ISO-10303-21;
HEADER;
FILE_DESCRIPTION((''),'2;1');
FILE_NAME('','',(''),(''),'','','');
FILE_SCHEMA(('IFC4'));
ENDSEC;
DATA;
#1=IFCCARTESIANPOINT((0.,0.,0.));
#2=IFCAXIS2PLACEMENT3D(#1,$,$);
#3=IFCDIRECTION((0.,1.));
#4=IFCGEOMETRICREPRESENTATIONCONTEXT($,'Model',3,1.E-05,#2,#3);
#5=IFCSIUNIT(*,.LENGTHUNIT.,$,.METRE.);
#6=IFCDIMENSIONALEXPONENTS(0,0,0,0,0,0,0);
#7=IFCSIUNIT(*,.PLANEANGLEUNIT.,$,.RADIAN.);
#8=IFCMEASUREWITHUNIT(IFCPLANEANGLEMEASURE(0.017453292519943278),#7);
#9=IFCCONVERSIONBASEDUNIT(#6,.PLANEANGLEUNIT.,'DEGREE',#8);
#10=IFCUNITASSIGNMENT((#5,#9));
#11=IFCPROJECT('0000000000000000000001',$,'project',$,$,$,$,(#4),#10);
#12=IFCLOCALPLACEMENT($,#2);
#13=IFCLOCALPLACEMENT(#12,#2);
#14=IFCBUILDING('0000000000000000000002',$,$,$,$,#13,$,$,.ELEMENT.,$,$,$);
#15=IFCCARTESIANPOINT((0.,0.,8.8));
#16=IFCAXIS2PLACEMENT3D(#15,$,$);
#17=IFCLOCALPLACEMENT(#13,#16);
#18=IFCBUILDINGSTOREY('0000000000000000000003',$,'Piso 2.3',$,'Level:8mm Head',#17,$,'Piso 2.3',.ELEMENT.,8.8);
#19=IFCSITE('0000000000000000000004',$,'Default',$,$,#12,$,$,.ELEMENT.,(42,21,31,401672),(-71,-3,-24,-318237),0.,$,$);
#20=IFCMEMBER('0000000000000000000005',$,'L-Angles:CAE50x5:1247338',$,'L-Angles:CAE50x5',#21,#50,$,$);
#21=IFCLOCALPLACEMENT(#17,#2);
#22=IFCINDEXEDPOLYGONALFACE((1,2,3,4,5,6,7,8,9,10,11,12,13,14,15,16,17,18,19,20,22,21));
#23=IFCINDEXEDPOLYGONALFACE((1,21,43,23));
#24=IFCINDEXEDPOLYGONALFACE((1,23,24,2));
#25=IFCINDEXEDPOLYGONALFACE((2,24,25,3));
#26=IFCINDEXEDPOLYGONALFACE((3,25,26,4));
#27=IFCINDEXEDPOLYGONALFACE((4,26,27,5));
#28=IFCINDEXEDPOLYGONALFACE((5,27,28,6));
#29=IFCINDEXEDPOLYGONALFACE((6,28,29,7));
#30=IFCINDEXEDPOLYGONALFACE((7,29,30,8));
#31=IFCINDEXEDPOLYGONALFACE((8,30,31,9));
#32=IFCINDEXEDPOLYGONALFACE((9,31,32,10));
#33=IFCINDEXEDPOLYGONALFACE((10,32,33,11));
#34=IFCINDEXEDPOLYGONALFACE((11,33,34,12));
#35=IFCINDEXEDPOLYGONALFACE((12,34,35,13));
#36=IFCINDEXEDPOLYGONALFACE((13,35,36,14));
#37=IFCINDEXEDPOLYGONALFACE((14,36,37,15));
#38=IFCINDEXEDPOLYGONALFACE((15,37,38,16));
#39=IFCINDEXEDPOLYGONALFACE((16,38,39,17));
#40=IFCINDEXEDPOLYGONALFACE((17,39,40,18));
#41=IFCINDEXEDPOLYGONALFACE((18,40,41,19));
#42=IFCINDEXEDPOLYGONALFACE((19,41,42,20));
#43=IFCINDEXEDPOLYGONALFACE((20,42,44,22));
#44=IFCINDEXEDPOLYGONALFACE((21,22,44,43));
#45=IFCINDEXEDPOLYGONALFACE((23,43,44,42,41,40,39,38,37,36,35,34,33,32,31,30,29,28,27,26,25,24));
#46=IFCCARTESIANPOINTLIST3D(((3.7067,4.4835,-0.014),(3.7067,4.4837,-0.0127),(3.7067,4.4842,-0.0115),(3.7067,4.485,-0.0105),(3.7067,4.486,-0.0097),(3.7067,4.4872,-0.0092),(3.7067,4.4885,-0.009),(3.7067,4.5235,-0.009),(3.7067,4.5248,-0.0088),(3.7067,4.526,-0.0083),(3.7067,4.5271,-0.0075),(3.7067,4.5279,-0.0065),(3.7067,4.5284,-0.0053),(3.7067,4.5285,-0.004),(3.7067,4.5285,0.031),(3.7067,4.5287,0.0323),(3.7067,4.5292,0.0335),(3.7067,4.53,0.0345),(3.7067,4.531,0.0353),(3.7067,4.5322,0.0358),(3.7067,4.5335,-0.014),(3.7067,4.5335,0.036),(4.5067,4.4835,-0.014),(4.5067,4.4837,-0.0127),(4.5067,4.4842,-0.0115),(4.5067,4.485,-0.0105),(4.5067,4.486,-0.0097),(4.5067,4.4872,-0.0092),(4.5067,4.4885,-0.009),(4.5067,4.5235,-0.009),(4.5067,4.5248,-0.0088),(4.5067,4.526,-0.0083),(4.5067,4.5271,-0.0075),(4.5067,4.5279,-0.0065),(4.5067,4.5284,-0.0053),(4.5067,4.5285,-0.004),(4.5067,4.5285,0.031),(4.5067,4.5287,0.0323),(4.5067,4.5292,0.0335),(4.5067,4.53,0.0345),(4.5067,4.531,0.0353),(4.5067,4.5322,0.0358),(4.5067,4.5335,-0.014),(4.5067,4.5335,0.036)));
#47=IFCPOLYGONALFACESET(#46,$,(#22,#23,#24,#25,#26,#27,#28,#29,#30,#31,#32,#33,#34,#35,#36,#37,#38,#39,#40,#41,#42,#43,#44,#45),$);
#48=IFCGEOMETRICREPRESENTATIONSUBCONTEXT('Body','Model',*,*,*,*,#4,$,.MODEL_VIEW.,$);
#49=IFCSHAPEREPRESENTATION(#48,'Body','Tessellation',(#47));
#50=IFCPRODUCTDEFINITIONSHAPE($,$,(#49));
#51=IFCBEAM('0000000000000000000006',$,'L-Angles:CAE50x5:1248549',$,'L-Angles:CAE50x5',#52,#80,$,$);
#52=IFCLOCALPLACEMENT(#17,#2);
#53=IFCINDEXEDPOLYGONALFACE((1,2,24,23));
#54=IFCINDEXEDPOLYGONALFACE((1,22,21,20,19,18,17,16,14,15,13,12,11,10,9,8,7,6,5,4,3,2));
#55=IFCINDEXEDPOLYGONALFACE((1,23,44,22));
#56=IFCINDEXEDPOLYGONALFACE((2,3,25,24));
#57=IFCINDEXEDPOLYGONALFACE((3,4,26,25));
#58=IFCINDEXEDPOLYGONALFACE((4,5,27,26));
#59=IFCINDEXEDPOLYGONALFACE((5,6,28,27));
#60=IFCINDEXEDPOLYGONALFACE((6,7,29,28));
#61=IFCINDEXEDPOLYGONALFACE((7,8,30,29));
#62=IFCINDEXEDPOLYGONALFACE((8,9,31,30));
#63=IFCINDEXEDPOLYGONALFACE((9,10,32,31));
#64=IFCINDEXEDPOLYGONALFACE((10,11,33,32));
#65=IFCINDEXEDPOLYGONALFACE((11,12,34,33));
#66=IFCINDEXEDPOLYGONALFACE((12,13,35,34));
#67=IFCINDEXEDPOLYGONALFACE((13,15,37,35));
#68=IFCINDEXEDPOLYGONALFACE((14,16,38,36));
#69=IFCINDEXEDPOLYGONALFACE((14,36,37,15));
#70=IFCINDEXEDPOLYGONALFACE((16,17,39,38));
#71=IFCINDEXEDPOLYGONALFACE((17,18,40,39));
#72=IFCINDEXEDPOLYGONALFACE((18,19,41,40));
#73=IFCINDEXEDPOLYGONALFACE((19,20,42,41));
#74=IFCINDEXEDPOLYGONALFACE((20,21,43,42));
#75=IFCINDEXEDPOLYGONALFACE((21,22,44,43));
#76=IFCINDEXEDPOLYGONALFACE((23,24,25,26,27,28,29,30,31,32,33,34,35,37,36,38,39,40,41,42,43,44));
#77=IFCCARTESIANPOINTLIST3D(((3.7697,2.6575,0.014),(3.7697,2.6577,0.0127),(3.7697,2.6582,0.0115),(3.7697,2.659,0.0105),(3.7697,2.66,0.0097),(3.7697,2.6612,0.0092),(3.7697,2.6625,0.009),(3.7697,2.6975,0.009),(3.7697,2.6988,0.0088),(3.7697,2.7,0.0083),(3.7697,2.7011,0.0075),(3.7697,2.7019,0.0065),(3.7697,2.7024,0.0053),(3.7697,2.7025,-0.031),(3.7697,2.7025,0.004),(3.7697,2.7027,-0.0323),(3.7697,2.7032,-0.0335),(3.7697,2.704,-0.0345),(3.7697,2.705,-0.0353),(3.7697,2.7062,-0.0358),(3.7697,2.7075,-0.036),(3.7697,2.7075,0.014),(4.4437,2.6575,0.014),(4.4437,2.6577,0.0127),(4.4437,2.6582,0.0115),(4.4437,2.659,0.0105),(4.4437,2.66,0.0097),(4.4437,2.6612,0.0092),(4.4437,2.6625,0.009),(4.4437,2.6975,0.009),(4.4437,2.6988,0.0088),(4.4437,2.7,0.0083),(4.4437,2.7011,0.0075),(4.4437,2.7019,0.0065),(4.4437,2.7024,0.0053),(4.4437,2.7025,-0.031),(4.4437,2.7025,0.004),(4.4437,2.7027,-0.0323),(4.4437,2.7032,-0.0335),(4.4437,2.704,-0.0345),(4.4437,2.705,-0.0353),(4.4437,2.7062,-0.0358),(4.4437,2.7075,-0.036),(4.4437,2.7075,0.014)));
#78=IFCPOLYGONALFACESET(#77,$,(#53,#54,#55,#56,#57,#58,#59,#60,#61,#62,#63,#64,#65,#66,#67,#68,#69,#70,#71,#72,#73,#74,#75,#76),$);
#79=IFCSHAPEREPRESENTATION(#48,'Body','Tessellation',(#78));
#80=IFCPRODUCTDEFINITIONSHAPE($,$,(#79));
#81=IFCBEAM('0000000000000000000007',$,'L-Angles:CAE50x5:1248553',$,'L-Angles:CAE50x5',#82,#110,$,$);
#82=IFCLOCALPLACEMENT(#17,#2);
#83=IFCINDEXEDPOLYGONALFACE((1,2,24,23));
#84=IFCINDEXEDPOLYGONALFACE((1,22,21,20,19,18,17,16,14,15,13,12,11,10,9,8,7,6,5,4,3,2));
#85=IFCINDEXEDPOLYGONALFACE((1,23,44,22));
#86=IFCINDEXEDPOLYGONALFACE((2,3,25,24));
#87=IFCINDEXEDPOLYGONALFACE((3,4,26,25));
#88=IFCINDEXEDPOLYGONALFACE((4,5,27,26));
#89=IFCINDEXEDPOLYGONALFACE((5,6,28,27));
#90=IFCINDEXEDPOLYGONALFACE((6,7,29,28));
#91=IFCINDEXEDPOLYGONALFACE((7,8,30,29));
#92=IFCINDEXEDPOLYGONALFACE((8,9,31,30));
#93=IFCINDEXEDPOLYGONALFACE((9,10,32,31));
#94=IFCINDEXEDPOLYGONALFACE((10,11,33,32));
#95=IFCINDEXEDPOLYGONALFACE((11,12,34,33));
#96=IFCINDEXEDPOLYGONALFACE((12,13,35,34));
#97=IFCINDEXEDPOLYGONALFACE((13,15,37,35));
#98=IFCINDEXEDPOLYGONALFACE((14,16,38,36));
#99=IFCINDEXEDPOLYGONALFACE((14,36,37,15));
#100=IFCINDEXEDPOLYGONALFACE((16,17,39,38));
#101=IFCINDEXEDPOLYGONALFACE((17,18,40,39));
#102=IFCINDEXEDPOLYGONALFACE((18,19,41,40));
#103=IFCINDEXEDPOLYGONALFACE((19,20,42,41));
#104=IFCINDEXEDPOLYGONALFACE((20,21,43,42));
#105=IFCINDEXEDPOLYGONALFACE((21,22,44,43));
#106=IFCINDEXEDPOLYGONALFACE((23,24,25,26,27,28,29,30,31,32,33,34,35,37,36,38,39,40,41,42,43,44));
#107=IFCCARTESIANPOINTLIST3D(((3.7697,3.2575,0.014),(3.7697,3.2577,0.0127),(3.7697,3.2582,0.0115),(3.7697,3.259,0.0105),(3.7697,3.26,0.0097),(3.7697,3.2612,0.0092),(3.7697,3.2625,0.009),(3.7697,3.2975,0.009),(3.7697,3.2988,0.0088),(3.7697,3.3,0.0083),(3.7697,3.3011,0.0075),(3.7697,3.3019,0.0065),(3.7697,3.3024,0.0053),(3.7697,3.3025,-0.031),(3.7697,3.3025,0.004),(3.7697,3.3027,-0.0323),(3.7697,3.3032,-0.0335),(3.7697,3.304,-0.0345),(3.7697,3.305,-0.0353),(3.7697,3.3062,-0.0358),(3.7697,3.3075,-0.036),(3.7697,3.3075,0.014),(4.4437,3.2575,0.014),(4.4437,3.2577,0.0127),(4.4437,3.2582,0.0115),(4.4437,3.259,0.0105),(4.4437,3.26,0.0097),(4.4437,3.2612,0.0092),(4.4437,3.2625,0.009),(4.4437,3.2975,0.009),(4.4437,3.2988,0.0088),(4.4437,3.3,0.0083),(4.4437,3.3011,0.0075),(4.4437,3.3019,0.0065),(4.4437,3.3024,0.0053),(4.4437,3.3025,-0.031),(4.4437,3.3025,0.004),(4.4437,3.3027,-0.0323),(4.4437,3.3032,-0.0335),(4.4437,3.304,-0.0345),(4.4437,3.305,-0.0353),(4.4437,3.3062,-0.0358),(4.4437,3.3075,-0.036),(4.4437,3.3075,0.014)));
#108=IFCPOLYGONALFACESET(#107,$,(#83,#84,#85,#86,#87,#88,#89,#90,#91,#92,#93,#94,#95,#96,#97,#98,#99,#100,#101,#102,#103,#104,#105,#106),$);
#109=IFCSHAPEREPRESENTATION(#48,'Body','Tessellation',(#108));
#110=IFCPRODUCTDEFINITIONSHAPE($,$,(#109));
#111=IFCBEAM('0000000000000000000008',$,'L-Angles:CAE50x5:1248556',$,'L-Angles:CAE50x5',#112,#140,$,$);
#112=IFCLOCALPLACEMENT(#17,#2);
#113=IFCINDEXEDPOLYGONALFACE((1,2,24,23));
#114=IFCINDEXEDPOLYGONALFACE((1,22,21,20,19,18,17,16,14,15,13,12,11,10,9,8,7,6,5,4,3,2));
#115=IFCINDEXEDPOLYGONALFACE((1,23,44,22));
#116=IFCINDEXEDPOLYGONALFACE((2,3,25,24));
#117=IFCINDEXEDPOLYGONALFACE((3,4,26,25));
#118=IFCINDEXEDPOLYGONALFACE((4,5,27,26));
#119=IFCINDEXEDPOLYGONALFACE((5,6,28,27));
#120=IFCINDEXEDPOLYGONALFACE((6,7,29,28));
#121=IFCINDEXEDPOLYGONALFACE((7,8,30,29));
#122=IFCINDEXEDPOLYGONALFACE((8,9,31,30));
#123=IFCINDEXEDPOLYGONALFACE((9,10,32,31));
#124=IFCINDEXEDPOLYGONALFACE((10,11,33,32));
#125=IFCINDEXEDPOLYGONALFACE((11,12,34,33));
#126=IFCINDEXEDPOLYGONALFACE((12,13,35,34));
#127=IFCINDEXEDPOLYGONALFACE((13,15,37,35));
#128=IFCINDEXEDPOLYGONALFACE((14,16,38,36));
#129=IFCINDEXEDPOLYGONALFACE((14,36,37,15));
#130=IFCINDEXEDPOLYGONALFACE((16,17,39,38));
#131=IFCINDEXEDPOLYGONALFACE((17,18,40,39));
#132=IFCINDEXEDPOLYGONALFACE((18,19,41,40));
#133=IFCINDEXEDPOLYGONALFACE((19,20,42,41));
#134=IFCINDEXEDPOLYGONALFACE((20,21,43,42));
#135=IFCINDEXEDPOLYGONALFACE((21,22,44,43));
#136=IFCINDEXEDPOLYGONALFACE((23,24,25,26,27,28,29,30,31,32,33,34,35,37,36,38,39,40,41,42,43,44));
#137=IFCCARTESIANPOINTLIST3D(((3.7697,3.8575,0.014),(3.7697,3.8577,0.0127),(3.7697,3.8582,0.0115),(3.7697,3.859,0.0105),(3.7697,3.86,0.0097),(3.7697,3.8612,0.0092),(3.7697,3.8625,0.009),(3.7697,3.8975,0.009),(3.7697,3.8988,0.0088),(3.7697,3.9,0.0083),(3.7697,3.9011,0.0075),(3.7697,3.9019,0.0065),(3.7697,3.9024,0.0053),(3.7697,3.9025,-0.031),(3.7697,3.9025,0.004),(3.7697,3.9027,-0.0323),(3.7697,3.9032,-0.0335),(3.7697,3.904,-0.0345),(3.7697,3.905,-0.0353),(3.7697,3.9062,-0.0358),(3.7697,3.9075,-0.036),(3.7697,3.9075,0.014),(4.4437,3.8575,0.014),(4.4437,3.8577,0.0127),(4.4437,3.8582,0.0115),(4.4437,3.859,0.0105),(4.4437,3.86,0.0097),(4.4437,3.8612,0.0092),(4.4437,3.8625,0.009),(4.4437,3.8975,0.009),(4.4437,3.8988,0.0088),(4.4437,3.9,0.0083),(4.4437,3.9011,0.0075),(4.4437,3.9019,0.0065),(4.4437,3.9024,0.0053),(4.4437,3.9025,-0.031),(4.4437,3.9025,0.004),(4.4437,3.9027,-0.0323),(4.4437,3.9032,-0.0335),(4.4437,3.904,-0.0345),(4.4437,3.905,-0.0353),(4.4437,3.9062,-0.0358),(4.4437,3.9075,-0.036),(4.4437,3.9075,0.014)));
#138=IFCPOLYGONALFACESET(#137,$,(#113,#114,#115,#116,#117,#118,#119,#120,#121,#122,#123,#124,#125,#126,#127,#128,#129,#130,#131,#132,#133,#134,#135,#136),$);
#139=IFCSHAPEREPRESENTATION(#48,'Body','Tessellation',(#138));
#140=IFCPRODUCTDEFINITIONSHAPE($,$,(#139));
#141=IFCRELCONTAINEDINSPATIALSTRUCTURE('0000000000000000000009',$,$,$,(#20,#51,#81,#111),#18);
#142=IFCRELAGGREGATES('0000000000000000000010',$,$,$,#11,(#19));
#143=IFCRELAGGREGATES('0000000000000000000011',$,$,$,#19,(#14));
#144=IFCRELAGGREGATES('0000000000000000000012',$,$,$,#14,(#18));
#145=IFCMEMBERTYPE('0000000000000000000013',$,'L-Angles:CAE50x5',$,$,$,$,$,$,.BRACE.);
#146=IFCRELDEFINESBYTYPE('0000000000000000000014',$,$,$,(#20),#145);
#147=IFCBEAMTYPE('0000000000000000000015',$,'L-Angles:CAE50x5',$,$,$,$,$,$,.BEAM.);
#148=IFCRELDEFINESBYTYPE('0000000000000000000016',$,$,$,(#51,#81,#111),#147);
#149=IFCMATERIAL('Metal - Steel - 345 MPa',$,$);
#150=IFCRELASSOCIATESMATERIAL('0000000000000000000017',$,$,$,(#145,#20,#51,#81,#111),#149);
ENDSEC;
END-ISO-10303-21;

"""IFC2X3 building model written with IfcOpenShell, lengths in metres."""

from ifc_helpers import new_model, entity, si_unit, converted_unit, direction, frame, frame_2d, origin, place, context, subcontext, project, spatial, polyline, circle_curve, parameter, trimmed, segment, composite_curve, outline, extrude, source, transform, mapped, material, type_object, type_shapes, element, save


model = new_model("IFC2X3")

# Units and contexts
model_context = context("Model", 3, precision=1e-05, world=origin(), true_north=direction((0.0, 1.0)))
body_context = subcontext(model_context, "Body", "Model", "MODEL_VIEW")
ifc_project = project(units=[si_unit("LENGTHUNIT", "METRE"), converted_unit("PLANEANGLEUNIT", "DEGREE", entity("IfcPlaneAngleMeasure", 0.017453292519943278), si_unit("PLANEANGLEUNIT", "RADIAN"), dimensions=[0, 0, 0, 0, 0, 0, 0])], contexts=[model_context])

# Site, building, storey
site_placement = place(None, origin())
site = spatial("IfcSite", under=ifc_project, at=site_placement, Name="Default", CompositionType="ELEMENT", RefLatitude=(42, 21, 31, 401672), RefLongitude=(-71, -3, -24, -318237), RefElevation=0.0)
building_placement = place(site_placement, origin())
building = spatial("IfcBuilding", under=site, at=building_placement, CompositionType="ELEMENT")
storey_placement = place(building_placement, frame((0.0, 0.0, 8.8)))
storey = spatial("IfcBuildingStorey", under=building, at=storey_placement, Name="Piso 2.3", ObjectType="Level:8mm Head", LongName="Piso 2.3", CompositionType="ELEMENT", Elevation=8.8)

# Member
ifc_material = material(Name="Metal - Steel - 345 MPa")
member_type_1 = type_object("IfcMemberType", Name="L-Angles:CAE50x5", PredefinedType="BRACE", material=ifc_material)
shared_shape_1 = source(origin(), body_context, "Body", "SweptSolid", [
    extrude(outline(composite_curve([segment(polyline([(-0.0164, -0.0164), (0.0336, -0.0164)]), True, "CONTINUOUS"), segment(trimmed(circle_curve(frame_2d((0.0286, -0.0164), x_axis=(1.0, 0.0)), 0.005), [parameter(0.0)], [parameter(90.0)], True, "PARAMETER"), True, "CONTINUOUS"), segment(polyline([(0.0286, -0.0114), (-0.0064, -0.0114)]), True, "CONTINUOUS"), segment(trimmed(circle_curve(frame_2d((-0.0064, -0.0064), x_axis=(1.0, 0.0)), 0.005), [parameter(180.0)], [parameter(270.0)], True, "PARAMETER"), False, "CONTINUOUS"), segment(polyline([(-0.0114, -0.0064), (-0.0114, 0.0286)]), True, "CONTINUOUS"), segment(trimmed(circle_curve(frame_2d((-0.0164, 0.0286), x_axis=(1.0, 0.0)), 0.005), [parameter(0.0)], [parameter(90.0)], True, "PARAMETER"), True, "CONTINUOUS"), segment(polyline([(-0.0164, 0.0336), (-0.0164, -0.0164)]), True, "CONTINUOUS")], self_intersect=False)), frame((-0.4, -0.0024, -0.0024), z_axis=(1.0, 0.0, 0.0), x_axis=(0.0, -1.0, 0.0)), (0.0, 0.0, 1.0), 0.8),
])
type_shapes(member_type_1, [shared_shape_1])
member_placement = place(storey_placement, frame((4.1067, 4.5195, 0.0), z_axis=(0.0, 1.0, 0.0), x_axis=(1.0, 0.0, 0.0)))
element("IfcMember", 1, at=member_placement, inside=storey, type_object=member_type_1, material=ifc_material, Name="L-Angles:CAE50x5:1247338", ObjectType="L-Angles:CAE50x5", context=body_context, shape_type="MappedRepresentation", body=[
    mapped(shared_shape_1, transform((0.0, 0.0, 0.0), scale=1.0)),
])

# Beams
beam_type_1 = type_object("IfcBeamType", Name="L-Angles:CAE50x5", PredefinedType="BEAM")
beam_1_placement = place(storey_placement, frame((3.7067, 2.6935, 0.0)))
element("IfcBeam", 2, at=beam_1_placement, inside=storey, type_object=beam_type_1, material=ifc_material, Name="L-Angles:CAE50x5:1248549", ObjectType="L-Angles:CAE50x5", context=body_context, shape_type="SweptSolid", body=[
    extrude(outline(composite_curve([segment(polyline([(-0.0336, -0.0164), (0.0164, -0.0164)]), True, "CONTINUOUS"), segment(polyline([(0.0164, -0.0164), (0.0164, 0.0336)]), True, "CONTINUOUS"), segment(trimmed(circle_curve(frame_2d((0.0164, 0.0286), x_axis=(0.0, 1.0)), 0.005), [parameter(0.0)], [parameter(90.0)], True, "PARAMETER"), True, "CONTINUOUS"), segment(polyline([(0.0114, 0.0286), (0.0114, -0.0064)]), True, "CONTINUOUS"), segment(trimmed(circle_curve(frame_2d((0.0064, -0.0064), x_axis=(1.0, 0.0)), 0.005), [parameter(270.0)], [parameter(0.0)], True, "PARAMETER"), False, "CONTINUOUS"), segment(polyline([(0.0064, -0.0114), (-0.0286, -0.0114)]), True, "CONTINUOUS"), segment(trimmed(circle_curve(frame_2d((-0.0286, -0.0164), x_axis=(0.0, 1.0)), 0.005), [parameter(0.0)], [parameter(90.0)], True, "PARAMETER"), True, "CONTINUOUS")], self_intersect=False)), frame((0.063, -0.0024, -0.0024), z_axis=(1.0, 0.0, 0.0), x_axis=(0.0, 0.0, 1.0)), (0.0, 0.0, 1.0), 0.674),
])
beam_2_placement = place(storey_placement, frame((3.7067, 3.2935, 0.0)))
element("IfcBeam", 3, at=beam_2_placement, inside=storey, type_object=beam_type_1, material=ifc_material, Name="L-Angles:CAE50x5:1248553", ObjectType="L-Angles:CAE50x5", context=body_context, shape_type="SweptSolid", body=[
    extrude(outline(composite_curve([segment(polyline([(-0.0336, -0.0164), (0.0164, -0.0164)]), True, "CONTINUOUS"), segment(polyline([(0.0164, -0.0164), (0.0164, 0.0336)]), True, "CONTINUOUS"), segment(trimmed(circle_curve(frame_2d((0.0164, 0.0286), x_axis=(0.0, 1.0)), 0.005), [parameter(0.0)], [parameter(90.0)], True, "PARAMETER"), True, "CONTINUOUS"), segment(polyline([(0.0114, 0.0286), (0.0114, -0.0064)]), True, "CONTINUOUS"), segment(trimmed(circle_curve(frame_2d((0.0064, -0.0064), x_axis=(1.0, 0.0)), 0.005), [parameter(270.0)], [parameter(0.0)], True, "PARAMETER"), False, "CONTINUOUS"), segment(polyline([(0.0064, -0.0114), (-0.0286, -0.0114)]), True, "CONTINUOUS"), segment(trimmed(circle_curve(frame_2d((-0.0286, -0.0164), x_axis=(0.0, 1.0)), 0.005), [parameter(0.0)], [parameter(90.0)], True, "PARAMETER"), True, "CONTINUOUS")], self_intersect=False)), frame((0.063, -0.0024, -0.0024), z_axis=(1.0, 0.0, 0.0), x_axis=(0.0, 0.0, 1.0)), (0.0, 0.0, 1.0), 0.674),
])
beam_3_placement = place(storey_placement, frame((3.7067, 3.8935, 0.0)))
element("IfcBeam", 4, at=beam_3_placement, inside=storey, type_object=beam_type_1, material=ifc_material, Name="L-Angles:CAE50x5:1248556", ObjectType="L-Angles:CAE50x5", context=body_context, shape_type="SweptSolid", body=[
    extrude(outline(composite_curve([segment(polyline([(-0.0336, -0.0164), (0.0164, -0.0164)]), True, "CONTINUOUS"), segment(polyline([(0.0164, -0.0164), (0.0164, 0.0336)]), True, "CONTINUOUS"), segment(trimmed(circle_curve(frame_2d((0.0164, 0.0286), x_axis=(0.0, 1.0)), 0.005), [parameter(0.0)], [parameter(90.0)], True, "PARAMETER"), True, "CONTINUOUS"), segment(polyline([(0.0114, 0.0286), (0.0114, -0.0064)]), True, "CONTINUOUS"), segment(trimmed(circle_curve(frame_2d((0.0064, -0.0064), x_axis=(1.0, 0.0)), 0.005), [parameter(270.0)], [parameter(0.0)], True, "PARAMETER"), False, "CONTINUOUS"), segment(polyline([(0.0064, -0.0114), (-0.0286, -0.0114)]), True, "CONTINUOUS"), segment(trimmed(circle_curve(frame_2d((-0.0286, -0.0164), x_axis=(0.0, 1.0)), 0.005), [parameter(0.0)], [parameter(90.0)], True, "PARAMETER"), True, "CONTINUOUS")], self_intersect=False)), frame((0.063, -0.0024, -0.0024), z_axis=(1.0, 0.0, 0.0), x_axis=(0.0, 0.0, 1.0)), (0.0, 0.0, 1.0), 0.674),
])

save(model, "model.ifc")
